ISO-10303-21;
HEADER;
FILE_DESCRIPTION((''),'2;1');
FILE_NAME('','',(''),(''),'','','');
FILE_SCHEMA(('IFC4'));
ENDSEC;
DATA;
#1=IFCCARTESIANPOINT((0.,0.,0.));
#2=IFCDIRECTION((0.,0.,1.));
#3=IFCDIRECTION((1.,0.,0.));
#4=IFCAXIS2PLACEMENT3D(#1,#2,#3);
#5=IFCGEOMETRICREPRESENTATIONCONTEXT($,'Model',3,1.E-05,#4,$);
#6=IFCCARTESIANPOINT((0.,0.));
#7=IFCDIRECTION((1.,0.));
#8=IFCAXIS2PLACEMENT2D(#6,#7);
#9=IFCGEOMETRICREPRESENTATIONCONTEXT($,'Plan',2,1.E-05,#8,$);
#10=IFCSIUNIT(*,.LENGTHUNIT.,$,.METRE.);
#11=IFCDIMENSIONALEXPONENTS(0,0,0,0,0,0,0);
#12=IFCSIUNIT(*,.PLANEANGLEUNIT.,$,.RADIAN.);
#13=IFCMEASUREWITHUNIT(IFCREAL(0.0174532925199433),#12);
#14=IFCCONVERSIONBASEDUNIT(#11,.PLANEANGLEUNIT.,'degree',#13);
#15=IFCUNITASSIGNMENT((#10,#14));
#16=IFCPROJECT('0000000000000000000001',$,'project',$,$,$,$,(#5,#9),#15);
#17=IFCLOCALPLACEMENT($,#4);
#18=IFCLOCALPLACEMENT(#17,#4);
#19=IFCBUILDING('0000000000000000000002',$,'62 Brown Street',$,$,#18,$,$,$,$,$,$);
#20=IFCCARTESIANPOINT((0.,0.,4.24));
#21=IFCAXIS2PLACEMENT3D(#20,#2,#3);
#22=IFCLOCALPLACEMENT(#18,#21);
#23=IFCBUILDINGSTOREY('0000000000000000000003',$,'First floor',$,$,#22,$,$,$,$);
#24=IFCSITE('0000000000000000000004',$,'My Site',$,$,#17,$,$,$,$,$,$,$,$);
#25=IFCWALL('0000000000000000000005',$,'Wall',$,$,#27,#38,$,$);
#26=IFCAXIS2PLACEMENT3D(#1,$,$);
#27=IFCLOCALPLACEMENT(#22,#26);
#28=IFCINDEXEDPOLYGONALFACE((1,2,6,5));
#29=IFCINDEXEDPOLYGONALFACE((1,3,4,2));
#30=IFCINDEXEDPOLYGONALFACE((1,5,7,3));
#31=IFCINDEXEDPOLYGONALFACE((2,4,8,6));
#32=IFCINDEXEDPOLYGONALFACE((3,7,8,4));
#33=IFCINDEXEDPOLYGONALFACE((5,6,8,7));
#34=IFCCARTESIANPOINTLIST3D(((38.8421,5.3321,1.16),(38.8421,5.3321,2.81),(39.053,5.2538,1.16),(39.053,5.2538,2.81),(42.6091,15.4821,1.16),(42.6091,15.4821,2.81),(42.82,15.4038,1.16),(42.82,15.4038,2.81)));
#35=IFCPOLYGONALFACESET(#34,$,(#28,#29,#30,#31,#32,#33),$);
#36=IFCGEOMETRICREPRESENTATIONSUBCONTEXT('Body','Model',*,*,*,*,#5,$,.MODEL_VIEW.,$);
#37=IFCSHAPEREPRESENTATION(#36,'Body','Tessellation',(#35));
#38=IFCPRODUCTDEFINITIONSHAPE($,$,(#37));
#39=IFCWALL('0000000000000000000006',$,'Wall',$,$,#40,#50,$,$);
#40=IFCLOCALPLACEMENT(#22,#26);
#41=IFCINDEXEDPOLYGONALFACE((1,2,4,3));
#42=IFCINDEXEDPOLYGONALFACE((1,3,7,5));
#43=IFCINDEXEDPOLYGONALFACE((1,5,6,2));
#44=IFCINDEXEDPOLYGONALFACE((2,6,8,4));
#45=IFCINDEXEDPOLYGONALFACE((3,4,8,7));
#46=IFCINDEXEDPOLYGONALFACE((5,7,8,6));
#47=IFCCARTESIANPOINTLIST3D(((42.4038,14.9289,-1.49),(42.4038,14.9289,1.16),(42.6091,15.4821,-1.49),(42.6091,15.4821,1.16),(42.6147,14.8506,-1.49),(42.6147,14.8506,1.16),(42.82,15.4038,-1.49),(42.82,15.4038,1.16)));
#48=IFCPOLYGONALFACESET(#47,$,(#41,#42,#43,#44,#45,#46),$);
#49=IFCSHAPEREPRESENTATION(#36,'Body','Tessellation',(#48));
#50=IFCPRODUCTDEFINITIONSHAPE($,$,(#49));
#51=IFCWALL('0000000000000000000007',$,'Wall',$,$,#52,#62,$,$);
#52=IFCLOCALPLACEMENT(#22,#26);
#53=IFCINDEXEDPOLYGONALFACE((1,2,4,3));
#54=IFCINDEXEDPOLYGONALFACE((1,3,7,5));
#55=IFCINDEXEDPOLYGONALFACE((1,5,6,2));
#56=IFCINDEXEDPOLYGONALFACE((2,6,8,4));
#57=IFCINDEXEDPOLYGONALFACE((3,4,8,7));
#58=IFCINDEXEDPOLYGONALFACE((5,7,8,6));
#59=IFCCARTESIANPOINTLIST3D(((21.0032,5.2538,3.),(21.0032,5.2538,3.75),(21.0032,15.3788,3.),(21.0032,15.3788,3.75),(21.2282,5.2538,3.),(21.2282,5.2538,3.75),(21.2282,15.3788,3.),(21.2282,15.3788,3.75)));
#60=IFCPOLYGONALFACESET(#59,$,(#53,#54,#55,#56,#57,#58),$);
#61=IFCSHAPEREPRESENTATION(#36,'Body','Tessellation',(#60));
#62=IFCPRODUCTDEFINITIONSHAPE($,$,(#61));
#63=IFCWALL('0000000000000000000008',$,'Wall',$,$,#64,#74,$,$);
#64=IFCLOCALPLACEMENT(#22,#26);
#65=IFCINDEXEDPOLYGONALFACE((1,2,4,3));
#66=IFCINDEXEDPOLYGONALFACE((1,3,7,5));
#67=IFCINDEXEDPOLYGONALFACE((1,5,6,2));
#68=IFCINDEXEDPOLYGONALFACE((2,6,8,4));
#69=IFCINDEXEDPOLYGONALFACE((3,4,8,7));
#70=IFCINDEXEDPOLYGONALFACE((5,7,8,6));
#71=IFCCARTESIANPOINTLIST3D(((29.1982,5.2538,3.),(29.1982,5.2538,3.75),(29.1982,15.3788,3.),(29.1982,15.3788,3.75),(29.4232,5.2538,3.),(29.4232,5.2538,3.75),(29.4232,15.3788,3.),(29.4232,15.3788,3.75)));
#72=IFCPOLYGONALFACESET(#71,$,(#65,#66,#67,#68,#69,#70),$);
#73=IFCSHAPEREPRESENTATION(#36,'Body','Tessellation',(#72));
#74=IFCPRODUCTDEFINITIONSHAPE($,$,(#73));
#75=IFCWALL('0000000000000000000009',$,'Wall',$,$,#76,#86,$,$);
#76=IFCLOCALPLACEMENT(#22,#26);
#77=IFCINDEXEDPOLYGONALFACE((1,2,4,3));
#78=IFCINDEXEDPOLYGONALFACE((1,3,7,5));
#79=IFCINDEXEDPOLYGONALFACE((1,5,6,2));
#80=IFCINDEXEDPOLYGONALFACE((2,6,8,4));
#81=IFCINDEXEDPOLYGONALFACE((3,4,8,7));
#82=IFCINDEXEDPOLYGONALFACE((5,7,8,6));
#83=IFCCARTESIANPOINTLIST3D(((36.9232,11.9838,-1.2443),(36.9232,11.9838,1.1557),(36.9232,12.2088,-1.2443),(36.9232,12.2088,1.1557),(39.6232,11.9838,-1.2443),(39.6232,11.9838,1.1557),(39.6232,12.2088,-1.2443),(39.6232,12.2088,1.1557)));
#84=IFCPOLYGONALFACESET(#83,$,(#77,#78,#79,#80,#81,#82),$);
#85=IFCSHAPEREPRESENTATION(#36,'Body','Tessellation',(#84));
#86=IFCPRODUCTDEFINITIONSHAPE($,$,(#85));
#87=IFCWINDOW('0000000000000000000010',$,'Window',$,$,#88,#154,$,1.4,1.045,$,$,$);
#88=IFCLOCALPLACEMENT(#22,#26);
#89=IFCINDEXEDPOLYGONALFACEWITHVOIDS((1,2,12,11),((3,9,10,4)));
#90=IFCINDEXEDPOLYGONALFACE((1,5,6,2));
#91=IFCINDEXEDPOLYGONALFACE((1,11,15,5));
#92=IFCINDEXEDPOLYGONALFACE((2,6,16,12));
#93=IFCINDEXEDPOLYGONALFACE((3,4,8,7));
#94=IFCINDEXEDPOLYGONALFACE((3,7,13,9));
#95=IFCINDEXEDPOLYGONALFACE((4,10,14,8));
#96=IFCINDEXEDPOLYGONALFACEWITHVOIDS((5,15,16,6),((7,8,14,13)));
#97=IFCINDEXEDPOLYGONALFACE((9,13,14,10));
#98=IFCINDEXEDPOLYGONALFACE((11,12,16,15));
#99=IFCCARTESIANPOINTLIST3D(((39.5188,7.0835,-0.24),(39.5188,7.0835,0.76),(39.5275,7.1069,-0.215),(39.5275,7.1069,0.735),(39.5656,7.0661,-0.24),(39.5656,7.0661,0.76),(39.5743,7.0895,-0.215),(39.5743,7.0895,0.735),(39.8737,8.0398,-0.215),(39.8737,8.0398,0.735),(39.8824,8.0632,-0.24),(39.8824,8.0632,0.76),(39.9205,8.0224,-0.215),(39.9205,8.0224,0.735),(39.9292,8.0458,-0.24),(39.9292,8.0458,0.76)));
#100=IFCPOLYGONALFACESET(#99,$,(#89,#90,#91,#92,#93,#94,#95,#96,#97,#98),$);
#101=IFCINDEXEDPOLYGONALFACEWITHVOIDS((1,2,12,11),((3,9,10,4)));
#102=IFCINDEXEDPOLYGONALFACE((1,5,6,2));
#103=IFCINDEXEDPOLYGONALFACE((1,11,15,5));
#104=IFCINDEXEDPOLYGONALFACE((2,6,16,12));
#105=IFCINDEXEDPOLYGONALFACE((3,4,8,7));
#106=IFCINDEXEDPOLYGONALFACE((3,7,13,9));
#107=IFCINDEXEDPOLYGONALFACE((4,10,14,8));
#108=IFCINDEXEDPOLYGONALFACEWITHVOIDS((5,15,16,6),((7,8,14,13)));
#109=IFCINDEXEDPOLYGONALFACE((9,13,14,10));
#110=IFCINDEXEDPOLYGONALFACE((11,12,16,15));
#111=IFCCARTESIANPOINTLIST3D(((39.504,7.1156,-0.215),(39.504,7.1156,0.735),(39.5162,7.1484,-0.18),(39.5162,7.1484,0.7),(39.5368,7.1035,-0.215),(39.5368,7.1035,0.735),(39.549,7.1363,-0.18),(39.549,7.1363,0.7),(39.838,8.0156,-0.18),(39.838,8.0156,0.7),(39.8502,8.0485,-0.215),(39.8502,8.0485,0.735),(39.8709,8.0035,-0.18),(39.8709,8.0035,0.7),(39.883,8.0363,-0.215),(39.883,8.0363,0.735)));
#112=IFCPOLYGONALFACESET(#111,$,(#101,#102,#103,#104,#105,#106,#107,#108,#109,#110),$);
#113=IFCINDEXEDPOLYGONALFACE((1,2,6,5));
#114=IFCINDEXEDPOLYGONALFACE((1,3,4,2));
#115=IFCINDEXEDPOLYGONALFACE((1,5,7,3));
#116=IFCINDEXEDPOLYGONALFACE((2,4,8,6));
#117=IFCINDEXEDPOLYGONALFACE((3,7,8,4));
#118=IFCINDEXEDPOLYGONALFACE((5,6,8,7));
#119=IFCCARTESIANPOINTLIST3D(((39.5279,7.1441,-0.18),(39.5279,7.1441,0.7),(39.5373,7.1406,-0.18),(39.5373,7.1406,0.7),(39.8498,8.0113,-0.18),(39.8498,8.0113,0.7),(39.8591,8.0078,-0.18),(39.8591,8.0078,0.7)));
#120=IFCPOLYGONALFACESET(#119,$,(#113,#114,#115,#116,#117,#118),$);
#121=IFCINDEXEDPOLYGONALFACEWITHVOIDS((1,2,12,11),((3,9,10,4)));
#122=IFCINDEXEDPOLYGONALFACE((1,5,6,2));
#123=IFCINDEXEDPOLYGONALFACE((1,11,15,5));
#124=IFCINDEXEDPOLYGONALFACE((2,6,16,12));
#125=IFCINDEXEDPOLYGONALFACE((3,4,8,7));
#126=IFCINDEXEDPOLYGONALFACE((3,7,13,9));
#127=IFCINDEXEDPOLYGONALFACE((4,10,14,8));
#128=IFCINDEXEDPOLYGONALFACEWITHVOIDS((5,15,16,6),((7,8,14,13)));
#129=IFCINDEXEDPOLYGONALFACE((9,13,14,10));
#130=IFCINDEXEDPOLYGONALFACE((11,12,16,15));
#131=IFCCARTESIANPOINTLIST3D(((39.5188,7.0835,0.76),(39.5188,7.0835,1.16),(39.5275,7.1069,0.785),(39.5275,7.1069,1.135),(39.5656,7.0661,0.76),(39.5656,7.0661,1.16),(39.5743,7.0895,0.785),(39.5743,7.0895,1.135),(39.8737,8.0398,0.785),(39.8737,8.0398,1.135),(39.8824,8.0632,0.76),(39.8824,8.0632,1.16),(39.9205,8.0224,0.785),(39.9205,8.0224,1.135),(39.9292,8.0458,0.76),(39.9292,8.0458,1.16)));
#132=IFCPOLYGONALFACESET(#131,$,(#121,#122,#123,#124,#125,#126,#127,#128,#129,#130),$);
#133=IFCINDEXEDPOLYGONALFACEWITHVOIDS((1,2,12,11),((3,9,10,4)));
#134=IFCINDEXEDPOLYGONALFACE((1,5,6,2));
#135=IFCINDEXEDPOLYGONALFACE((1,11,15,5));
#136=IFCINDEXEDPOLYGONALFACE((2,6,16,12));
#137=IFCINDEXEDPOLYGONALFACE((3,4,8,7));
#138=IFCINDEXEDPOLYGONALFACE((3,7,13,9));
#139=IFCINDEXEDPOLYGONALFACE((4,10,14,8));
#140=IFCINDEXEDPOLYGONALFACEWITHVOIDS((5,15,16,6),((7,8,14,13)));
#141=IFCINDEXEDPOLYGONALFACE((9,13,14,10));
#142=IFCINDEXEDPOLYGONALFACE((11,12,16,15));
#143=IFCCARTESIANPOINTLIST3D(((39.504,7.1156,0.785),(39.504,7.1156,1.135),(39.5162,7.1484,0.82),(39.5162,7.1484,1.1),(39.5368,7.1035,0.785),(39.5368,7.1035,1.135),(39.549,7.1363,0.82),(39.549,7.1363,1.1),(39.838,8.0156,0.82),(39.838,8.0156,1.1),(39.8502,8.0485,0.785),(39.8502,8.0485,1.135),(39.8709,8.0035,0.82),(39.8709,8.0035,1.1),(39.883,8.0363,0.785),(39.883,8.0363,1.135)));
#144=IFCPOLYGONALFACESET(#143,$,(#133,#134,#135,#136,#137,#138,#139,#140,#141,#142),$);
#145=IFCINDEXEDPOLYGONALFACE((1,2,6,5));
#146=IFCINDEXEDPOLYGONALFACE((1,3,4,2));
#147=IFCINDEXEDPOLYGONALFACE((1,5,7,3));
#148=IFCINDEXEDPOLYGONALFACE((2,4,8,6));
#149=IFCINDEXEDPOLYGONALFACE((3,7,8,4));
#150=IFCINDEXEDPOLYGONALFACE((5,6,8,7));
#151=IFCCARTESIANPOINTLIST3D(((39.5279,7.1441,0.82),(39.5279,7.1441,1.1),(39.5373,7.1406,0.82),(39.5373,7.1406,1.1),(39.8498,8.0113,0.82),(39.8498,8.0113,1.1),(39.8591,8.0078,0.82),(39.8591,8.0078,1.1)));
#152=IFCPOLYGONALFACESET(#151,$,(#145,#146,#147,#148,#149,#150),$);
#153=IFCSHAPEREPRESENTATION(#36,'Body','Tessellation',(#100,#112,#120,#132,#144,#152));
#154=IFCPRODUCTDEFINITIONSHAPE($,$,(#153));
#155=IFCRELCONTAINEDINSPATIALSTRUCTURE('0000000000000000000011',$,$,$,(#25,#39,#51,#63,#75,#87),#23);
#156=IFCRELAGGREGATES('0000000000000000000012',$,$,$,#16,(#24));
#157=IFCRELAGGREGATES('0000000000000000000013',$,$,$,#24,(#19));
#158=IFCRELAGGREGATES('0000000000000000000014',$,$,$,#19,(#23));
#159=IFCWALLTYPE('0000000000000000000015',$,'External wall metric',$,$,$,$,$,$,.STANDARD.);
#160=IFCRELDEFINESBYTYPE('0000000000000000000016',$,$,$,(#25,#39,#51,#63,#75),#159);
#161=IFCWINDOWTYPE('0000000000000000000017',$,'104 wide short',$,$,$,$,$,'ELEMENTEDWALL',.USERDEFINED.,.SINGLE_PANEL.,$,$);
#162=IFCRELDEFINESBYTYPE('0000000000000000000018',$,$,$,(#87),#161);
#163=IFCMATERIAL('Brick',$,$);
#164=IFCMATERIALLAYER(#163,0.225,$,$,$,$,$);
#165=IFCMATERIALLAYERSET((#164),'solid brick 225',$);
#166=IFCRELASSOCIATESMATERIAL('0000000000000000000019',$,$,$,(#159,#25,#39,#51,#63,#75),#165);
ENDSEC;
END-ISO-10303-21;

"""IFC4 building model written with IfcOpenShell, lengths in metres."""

from ifc_helpers import new_model, entity, si_unit, converted_unit, frame, origin_with_axes, origin_2d_with_axis, place, context, subcontext, project, spatial, line, indexed_curve, outline, extrude, shape, source, transform, mapped, material, layer, layer_set, layer_usage, type_object, type_shapes, element, save


model = new_model("IFC4")

# Units and contexts
model_context = context("Model", 3, precision=1e-05, world=origin_with_axes())
plan_context = context("Plan", 2, precision=1e-05, world=origin_2d_with_axis())
body_context_1 = subcontext(model_context, "Body", "Model", "MODEL_VIEW")
body_context_2 = subcontext(plan_context, "Body", "Plan", "PLAN_VIEW")
ifc_project = project(units=[si_unit("LENGTHUNIT", "METRE"), converted_unit("PLANEANGLEUNIT", "degree", entity("IfcReal", 0.0174532925199433), si_unit("PLANEANGLEUNIT", "RADIAN"), dimensions=[0, 0, 0, 0, 0, 0, 0])], contexts=[model_context, plan_context])

# Site, building, storey
site_placement = place(None, origin_with_axes())
site = spatial("IfcSite", under=ifc_project, at=site_placement, Name="My Site")
building_placement = place(site_placement, origin_with_axes())
building = spatial("IfcBuilding", under=site, at=building_placement, Name="62 Brown Street")
storey_placement = place(building_placement, frame((0.0, 0.0, 4.24), z_axis=(0.0, 0.0, 1.0), x_axis=(1.0, 0.0, 0.0)))
storey = spatial("IfcBuildingStorey", under=building, at=storey_placement, Name="First floor")

# Shared definitions
ifc_material_1 = material(Name="Brick")
ifc_layer_1 = layer(ifc_material_1, 0.225)
ifc_layer_set_1 = layer_set([ifc_layer_1], Name="solid brick 225")
wall_type_1 = type_object("IfcWallType", Name="External wall metric", PredefinedType="STANDARD", material=ifc_layer_set_1)

# Shared definitions
window_type = type_object("IfcWindowType", Name="104 wide short", ElementType="ELEMENTEDWALL", PartitioningType="SINGLE_PANEL", PredefinedType="USERDEFINED")
shared_shape_1 = source(origin_with_axes(), body_context_1, "Body", "SweptSolid", [
    extrude(outline(indexed_curve([(0.0, 0.0), (1.045, 0.0), (1.045, 1.0), (0.0, 1.0)], segments=[line(1, 2, 3, 4, 1)]), holes=[indexed_curve([(0.025, 0.025), (1.02, 0.025), (1.02, 0.975), (0.025, 0.975)], segments=[line(1, 2, 3, 4, 1)])]), frame((0.0, 0.15, 0.0), z_axis=(0.0, -1.0, 0.0), x_axis=(1.0, 0.0, 0.0)), (0.0, 0.0, -1.0), 0.05),
    extrude(outline(indexed_curve([(0.0, 0.0), (0.995, 0.0), (0.995, 0.95), (0.0, 0.95)], segments=[line(1, 2, 3, 4, 1)]), holes=[indexed_curve([(0.035, 0.035), (0.96, 0.035), (0.96, 0.915), (0.035, 0.915)], segments=[line(1, 2, 3, 4, 1)])]), frame((0.025, 0.19, 0.025), z_axis=(0.0, -1.0, 0.0), x_axis=(1.0, 0.0, 0.0)), (0.0, 0.0, -1.0), 0.035),
    extrude(outline(indexed_curve([(0.035, 0.035), (0.96, 0.035), (0.96, 0.915), (0.035, 0.915)], segments=[line(1, 2, 3, 4, 1)])), frame((0.025, 0.2025, 0.025), z_axis=(0.0, -1.0, 0.0), x_axis=(1.0, 0.0, 0.0)), (0.0, 0.0, -1.0), 0.01),
    extrude(outline(indexed_curve([(0.0, 0.0), (1.045, 0.0), (1.045, 0.4), (0.0, 0.4)], segments=[line(1, 2, 3, 4, 1)]), holes=[indexed_curve([(0.025, 0.025), (1.02, 0.025), (1.02, 0.375), (0.025, 0.375)], segments=[line(1, 2, 3, 4, 1)])]), frame((0.0, 0.15, 1.0), z_axis=(0.0, -1.0, 0.0), x_axis=(1.0, 0.0, 0.0)), (0.0, 0.0, -1.0), 0.05),
    extrude(outline(indexed_curve([(0.0, 0.0), (0.995, 0.0), (0.995, 0.35), (0.0, 0.35)], segments=[line(1, 2, 3, 4, 1)]), holes=[indexed_curve([(0.035, 0.035), (0.96, 0.035), (0.96, 0.315), (0.035, 0.315)], segments=[line(1, 2, 3, 4, 1)])]), frame((0.025, 0.19, 1.025), z_axis=(0.0, -1.0, 0.0), x_axis=(1.0, 0.0, 0.0)), (0.0, 0.0, -1.0), 0.035),
    extrude(outline(indexed_curve([(0.035, 0.035), (0.96, 0.035), (0.96, 0.315), (0.035, 0.315)], segments=[line(1, 2, 3, 4, 1)])), frame((0.025, 0.2025, 1.025), z_axis=(0.0, -1.0, 0.0), x_axis=(1.0, 0.0, 0.0)), (0.0, 0.0, -1.0), 0.01),
])
shared_shape_2 = source(origin_with_axes(), body_context_2, "Body", "Curve2D", [
    entity("IfcIndexedPolyCurve", entity("IfcCartesianPointList2D", [[0.025, 0.15], [1.02, 0.15]])),
    entity("IfcIndexedPolyCurve", entity("IfcCartesianPointList2D", [[0.0, 0.2], [0.025, 0.2], [0.025, 0.15], [0.0, 0.15]]), [entity("IfcLineIndex", [1, 2, 3, 4, 1])]),
    entity("IfcIndexedPolyCurve", entity("IfcCartesianPointList2D", [[1.045, 0.2], [1.02, 0.2], [1.02, 0.15], [1.045, 0.15]]), [entity("IfcLineIndex", [1, 2, 3, 4, 1])]),
    entity("IfcIndexedPolyCurve", entity("IfcCartesianPointList2D", [[0.025, 0.19], [0.06, 0.19], [0.06, 0.225], [0.025, 0.225]]), [entity("IfcLineIndex", [1, 2, 3, 4, 1])]),
    entity("IfcIndexedPolyCurve", entity("IfcCartesianPointList2D", [[1.02, 0.19], [0.985, 0.19], [0.985, 0.225], [1.02, 0.225]]), [entity("IfcLineIndex", [1, 2, 3, 4, 1])]),
    entity("IfcIndexedPolyCurve", entity("IfcCartesianPointList2D", [[0.06, 0.19], [0.985, 0.19]])),
    entity("IfcIndexedPolyCurve", entity("IfcCartesianPointList2D", [[0.06, 0.225], [0.985, 0.225]])),
    entity("IfcIndexedPolyCurve", entity("IfcCartesianPointList2D", [[0.06, 0.2075], [0.985, 0.2075]])),
])
type_shapes(window_type, [shared_shape_1, shared_shape_2])

# Walls
ifc_layer_usage_1 = layer_usage(ifc_layer_set_1, "AXIS2", "POSITIVE", 0.0)
wall_1_placement = place(storey_placement, frame((39.053, 5.2538, 1.16), z_axis=(0.0, 0.0, 1.0), x_axis=(0.347944, 0.937515, 0.0)))
element("IfcWall", 1, at=wall_1_placement, inside=storey, type_object=wall_type_1, material=ifc_layer_usage_1, Name="Wall", context=body_context_1, shape_type="SweptSolid", body=[
    extrude(outline(indexed_curve([(0.0, 0.0), (0.0, 0.225), (10.8265, 0.225), (10.8265, 0.0), (0.0, 0.0)], self_intersect=False)), origin_with_axes(), (0.0, 0.0, 1.0), 1.65),
])
ifc_layer_usage_2 = layer_usage(ifc_layer_set_1, "AXIS2", "POSITIVE", 0.0)
wall_2_placement = place(storey_placement, frame((42.6147, 14.8506, -1.49), z_axis=(0.0, 0.0, 1.0), x_axis=(0.347944, 0.937515, 0.0)))
element("IfcWall", 2, at=wall_2_placement, inside=storey, type_object=wall_type_1, material=ifc_layer_usage_2, Name="Wall", context=body_context_1, shape_type="SweptSolid", body=[
    extrude(outline(indexed_curve([(0.0, 0.0), (0.0, 0.225), (0.5901, 0.225), (0.5901, 0.0), (0.0, 0.0)], self_intersect=False)), origin_with_axes(), (0.0, 0.0, 1.0), 2.65),
])
ifc_layer_usage_3 = layer_usage(ifc_layer_set_1, "AXIS2", "POSITIVE", 0.0)
wall_3_placement = place(storey_placement, frame((21.0032, 15.3788, 3.0), z_axis=(0.0, 0.0, 1.0), x_axis=(0.0, -1.0, 0.0)))
element("IfcWall", 3, at=wall_3_placement, inside=storey, type_object=wall_type_1, material=ifc_layer_usage_3, Name="Wall", context=body_context_1, shape_type="SweptSolid", body=[
    extrude(outline(indexed_curve([(0.0, 0.0), (0.0, 0.225), (10.125, 0.225), (10.125, 0.0), (0.0, 0.0)], self_intersect=False)), origin_with_axes(), (0.0, 0.0, 1.0), 0.75),
])
ifc_layer_usage_4 = layer_usage(ifc_layer_set_1, "AXIS2", "POSITIVE", 0.0)
wall_4_placement = place(storey_placement, frame((29.4232, 5.2538, 3.0), z_axis=(0.0, 0.0, 1.0), x_axis=(0.0, 1.0, 0.0)))
element("IfcWall", 4, at=wall_4_placement, inside=storey, type_object=wall_type_1, material=ifc_layer_usage_4, Name="Wall", context=body_context_1, shape_type="SweptSolid", body=[
    extrude(outline(indexed_curve([(0.0, 0.0), (0.0, 0.225), (10.125, 0.225), (10.125, 0.0), (0.0, 0.0)], self_intersect=False)), origin_with_axes(), (0.0, 0.0, 1.0), 0.75),
])
ifc_layer_usage_5 = layer_usage(ifc_layer_set_1, "AXIS2", "POSITIVE", 0.0)
wall_5_placement = place(storey_placement, frame((36.9232, 11.9838, -1.2443), z_axis=(0.0, 0.0, 1.0), x_axis=(1.0, 0.0, 0.0)))
element("IfcWall", 5, at=wall_5_placement, inside=storey, type_object=wall_type_1, material=ifc_layer_usage_5, Name="Wall", context=body_context_1, shape_type="SweptSolid", body=[
    extrude(outline(indexed_curve([(0.0, 0.0), (0.0, 0.225), (2.7, 0.225), (2.7, 0.0), (0.0, 0.0)], self_intersect=False)), origin_with_axes(), (0.0, 0.0, 1.0), 2.4),
])

# Window
for number, where, z_axis, x_axis, name in (
    (6, (39.7063, 7.0139, -0.24), (0.0, 0.0, 1.0), (0.347944, 0.937515, 0.0), "Window"),
):
    element("IfcWindow", number, at=place(storey_placement, frame(where, z_axis=z_axis, x_axis=x_axis)), inside=storey, type_object=window_type, Name=name, OverallHeight=1.4, OverallWidth=1.045, shapes=[
        shape(body_context_1, "Body", "MappedRepresentation", [mapped(shared_shape_1, transform((0.0, 0.0, 0.0), x_axis=(1.0, 0.0, 0.0), y_axis=(0.0, 1.0, 0.0), z_axis=(0.0, 0.0, 1.0), scale=1.0))]),
        shape(body_context_2, "Body", "MappedRepresentation", [mapped(shared_shape_2, transform((0.0, 0.0, 0.0), x_axis=(1.0, 0.0, 0.0), y_axis=(0.0, 1.0, 0.0), z_axis=(0.0, 0.0, 1.0), scale=1.0))]),
    ])

save(model, "model.ifc")
